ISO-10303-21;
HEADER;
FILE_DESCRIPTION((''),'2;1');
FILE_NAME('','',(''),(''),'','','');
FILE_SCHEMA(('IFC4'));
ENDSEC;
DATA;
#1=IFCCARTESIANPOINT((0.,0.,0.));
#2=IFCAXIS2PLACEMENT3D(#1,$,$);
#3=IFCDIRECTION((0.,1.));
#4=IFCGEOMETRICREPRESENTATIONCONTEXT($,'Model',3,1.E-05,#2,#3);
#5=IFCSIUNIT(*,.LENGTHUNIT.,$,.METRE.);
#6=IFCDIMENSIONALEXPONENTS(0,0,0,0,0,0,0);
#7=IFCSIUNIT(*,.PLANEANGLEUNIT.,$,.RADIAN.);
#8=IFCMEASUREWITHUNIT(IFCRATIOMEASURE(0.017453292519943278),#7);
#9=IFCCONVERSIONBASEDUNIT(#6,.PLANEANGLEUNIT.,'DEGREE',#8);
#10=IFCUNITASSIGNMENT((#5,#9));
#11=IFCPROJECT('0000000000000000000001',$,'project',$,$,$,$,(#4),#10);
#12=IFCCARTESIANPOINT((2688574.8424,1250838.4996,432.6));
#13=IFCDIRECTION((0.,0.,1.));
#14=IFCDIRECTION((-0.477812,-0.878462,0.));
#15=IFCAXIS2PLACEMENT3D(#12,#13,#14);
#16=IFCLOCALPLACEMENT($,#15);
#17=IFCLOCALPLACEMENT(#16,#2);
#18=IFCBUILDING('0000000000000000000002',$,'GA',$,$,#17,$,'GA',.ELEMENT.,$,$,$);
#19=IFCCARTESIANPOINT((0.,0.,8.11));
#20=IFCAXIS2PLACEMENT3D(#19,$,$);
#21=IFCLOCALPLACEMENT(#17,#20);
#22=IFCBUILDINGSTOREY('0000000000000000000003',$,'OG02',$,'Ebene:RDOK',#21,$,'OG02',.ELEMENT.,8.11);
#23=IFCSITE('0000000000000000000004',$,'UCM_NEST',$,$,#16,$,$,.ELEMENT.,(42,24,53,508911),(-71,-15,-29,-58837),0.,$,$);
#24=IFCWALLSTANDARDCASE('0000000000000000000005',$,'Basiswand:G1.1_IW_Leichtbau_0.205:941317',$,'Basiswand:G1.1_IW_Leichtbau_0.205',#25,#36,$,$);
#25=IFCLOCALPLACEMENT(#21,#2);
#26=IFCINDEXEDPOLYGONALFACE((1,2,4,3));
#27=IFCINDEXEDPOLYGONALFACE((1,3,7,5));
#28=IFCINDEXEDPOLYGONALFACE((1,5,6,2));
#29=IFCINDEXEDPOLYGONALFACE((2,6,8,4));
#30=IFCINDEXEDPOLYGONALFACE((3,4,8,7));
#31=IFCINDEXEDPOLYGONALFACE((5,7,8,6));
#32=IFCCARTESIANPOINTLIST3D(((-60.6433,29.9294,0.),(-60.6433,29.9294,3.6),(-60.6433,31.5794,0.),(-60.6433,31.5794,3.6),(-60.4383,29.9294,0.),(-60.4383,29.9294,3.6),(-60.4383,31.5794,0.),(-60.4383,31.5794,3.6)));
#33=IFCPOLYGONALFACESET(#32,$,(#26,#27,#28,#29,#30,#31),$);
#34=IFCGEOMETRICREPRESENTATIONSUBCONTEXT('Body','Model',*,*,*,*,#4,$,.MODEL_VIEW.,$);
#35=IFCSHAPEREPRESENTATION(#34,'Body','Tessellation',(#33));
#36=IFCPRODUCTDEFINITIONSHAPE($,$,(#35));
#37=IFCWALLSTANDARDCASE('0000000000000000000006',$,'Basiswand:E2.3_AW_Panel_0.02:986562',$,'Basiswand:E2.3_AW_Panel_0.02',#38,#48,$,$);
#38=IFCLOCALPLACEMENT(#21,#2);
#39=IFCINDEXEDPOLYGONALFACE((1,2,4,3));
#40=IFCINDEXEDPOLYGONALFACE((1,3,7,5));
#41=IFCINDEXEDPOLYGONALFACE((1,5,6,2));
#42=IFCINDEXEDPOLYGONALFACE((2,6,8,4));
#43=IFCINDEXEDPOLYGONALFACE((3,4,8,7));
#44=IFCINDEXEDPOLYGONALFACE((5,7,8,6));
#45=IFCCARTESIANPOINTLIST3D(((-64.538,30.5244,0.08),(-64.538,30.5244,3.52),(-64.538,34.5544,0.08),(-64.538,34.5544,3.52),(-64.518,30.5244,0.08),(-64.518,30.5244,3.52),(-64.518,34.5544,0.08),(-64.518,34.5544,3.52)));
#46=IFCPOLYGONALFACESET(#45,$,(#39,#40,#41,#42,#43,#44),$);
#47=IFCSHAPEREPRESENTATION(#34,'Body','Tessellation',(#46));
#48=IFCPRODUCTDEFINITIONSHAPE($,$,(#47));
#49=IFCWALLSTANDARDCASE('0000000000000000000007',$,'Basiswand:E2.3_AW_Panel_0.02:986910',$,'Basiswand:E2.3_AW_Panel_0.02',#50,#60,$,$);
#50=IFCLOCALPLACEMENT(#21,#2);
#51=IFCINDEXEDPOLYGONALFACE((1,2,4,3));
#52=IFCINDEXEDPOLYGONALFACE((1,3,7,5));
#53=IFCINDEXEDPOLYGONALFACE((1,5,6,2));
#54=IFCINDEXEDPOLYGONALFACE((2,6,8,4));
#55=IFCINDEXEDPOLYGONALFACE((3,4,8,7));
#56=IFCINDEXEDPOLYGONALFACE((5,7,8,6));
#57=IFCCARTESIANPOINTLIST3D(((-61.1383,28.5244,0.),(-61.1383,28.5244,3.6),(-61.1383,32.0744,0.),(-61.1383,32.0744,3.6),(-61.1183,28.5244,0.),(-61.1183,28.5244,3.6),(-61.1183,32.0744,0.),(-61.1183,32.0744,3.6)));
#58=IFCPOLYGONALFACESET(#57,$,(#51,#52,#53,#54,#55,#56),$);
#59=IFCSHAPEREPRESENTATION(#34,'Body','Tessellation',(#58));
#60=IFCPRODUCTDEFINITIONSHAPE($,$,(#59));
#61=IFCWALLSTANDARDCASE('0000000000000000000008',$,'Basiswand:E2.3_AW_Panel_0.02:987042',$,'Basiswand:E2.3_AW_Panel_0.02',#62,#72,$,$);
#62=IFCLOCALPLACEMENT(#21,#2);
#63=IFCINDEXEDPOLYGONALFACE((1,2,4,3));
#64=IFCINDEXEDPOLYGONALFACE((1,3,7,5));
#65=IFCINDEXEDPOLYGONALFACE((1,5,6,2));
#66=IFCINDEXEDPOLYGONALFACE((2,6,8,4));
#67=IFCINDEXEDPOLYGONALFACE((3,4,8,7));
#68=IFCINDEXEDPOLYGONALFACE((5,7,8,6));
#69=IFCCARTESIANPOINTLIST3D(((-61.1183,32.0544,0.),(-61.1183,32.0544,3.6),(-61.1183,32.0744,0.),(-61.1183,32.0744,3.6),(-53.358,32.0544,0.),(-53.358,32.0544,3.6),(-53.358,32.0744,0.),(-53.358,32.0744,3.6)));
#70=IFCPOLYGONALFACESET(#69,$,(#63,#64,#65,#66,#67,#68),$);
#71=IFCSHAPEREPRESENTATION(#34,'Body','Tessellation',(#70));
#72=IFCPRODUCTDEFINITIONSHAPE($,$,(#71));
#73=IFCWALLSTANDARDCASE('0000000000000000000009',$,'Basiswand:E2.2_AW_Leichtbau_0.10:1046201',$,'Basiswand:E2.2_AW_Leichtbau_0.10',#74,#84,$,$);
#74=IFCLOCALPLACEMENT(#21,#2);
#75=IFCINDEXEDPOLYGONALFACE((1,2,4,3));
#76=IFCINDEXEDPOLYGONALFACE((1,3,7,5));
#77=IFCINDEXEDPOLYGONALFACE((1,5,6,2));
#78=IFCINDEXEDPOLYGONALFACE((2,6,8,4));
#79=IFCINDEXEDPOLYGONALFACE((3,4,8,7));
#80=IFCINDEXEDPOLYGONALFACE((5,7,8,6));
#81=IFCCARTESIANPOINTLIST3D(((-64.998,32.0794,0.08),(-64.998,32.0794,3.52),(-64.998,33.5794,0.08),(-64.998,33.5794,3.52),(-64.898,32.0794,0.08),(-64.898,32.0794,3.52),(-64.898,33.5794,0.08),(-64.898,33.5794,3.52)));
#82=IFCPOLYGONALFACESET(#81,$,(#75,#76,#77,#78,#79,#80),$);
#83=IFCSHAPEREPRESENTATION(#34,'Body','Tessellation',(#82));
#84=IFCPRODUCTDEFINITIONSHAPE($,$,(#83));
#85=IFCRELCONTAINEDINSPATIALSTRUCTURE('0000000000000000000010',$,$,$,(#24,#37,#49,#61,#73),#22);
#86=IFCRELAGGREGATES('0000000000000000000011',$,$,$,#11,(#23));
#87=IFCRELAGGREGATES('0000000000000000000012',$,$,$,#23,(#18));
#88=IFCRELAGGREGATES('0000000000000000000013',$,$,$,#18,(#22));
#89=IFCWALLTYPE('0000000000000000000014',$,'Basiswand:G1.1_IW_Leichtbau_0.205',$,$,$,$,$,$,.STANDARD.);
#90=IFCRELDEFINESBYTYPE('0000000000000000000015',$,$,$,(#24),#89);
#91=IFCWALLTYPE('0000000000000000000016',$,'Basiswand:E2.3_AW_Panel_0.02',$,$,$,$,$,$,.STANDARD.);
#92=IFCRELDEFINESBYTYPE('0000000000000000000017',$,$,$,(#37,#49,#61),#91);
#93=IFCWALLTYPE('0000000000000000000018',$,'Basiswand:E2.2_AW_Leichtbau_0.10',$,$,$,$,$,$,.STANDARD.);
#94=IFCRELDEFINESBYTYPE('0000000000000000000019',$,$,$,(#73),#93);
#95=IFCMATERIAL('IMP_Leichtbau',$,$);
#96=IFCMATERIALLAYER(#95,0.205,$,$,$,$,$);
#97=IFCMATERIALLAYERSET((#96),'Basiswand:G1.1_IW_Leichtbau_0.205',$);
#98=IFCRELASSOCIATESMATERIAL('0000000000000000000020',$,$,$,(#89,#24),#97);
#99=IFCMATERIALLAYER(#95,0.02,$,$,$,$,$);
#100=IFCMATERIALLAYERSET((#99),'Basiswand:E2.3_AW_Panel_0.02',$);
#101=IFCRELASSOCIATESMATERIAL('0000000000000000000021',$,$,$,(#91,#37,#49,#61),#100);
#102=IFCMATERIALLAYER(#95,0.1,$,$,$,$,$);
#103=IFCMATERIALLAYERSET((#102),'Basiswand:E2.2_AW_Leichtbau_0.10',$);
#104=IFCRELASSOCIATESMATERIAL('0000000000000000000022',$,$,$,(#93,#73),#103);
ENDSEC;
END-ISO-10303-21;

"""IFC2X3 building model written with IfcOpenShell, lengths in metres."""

from ifc_helpers import new_model, entity, si_unit, converted_unit, direction, frame, frame_2d, origin, place, context, subcontext, project, spatial, polyline, rectangle, extrude, clip, bounded_halfspace, material, layer, layer_set, layer_usage, type_object, element, save


model = new_model("IFC2X3")

# Units and contexts
model_context = context("Model", 3, precision=1e-05, world=origin(), true_north=direction((0.0, 1.0)))
body_context = subcontext(model_context, "Body", "Model", "MODEL_VIEW")
ifc_project = project(units=[si_unit("LENGTHUNIT", "METRE"), converted_unit("PLANEANGLEUNIT", "DEGREE", entity("IfcRatioMeasure", 0.017453292519943278), si_unit("PLANEANGLEUNIT", "RADIAN"), dimensions=[0, 0, 0, 0, 0, 0, 0])], contexts=[model_context])

# Site, building, storey
site_placement = place(None, frame((2688574.8424, 1250838.4996, 432.6), z_axis=(0.0, 0.0, 1.0), x_axis=(-0.477812, -0.878462, 0.0)))
site = spatial("IfcSite", under=ifc_project, at=site_placement, Name="UCM_NEST", CompositionType="ELEMENT", RefLatitude=(42, 24, 53, 508911), RefLongitude=(-71, -15, -29, -58837), RefElevation=0.0)
building_placement = place(site_placement, origin())
building = spatial("IfcBuilding", under=site, at=building_placement, Name="GA", LongName="GA", CompositionType="ELEMENT")
storey_placement = place(building_placement, frame((0.0, 0.0, 8.11)))
storey = spatial("IfcBuildingStorey", under=building, at=storey_placement, Name="OG02", ObjectType="Ebene:RDOK", LongName="OG02", CompositionType="ELEMENT", Elevation=8.11)

# Walls
ifc_material_1 = material(Name="IMP_Leichtbau")
ifc_layer_1 = layer(ifc_material_1, 0.205)
ifc_layer_set_1 = layer_set([ifc_layer_1], Name="Basiswand:G1.1_IW_Leichtbau_0.205")
ifc_layer_usage_1 = layer_usage(ifc_layer_set_1, "AXIS2", "NEGATIVE", 0.1025)
wall_type_1 = type_object("IfcWallType", Name="Basiswand:G1.1_IW_Leichtbau_0.205", PredefinedType="STANDARD", material=ifc_layer_set_1)
wall_1_placement = place(storey_placement, frame((-60.5408, 31.5794, 0.0), z_axis=(0.0, 0.0, 1.0), x_axis=(0.0, -1.0, 0.0)))
element("IfcWallStandardCase", 1, at=wall_1_placement, inside=storey, type_object=wall_type_1, material=ifc_layer_usage_1, Name="Basiswand:G1.1_IW_Leichtbau_0.205:941317", ObjectType="Basiswand:G1.1_IW_Leichtbau_0.205", context=body_context, shape_type="SweptSolid", body=[
    extrude(rectangle(XDim=1.65, YDim=0.205, at=frame_2d((0.825, 0.0), x_axis=(-1.0, 0.0))), origin(), (0.0, 0.0, 1.0), 3.6),
])
ifc_layer_2 = layer(ifc_material_1, 0.02)
ifc_layer_set_2 = layer_set([ifc_layer_2], Name="Basiswand:E2.3_AW_Panel_0.02")
ifc_layer_usage_2 = layer_usage(ifc_layer_set_2, "AXIS2", "NEGATIVE", 0.01)
wall_type_2 = type_object("IfcWallType", Name="Basiswand:E2.3_AW_Panel_0.02", PredefinedType="STANDARD", material=ifc_layer_set_2)
wall_2_placement = place(storey_placement, frame((-64.528, 34.5544, 0.08), z_axis=(0.0, 0.0, 1.0), x_axis=(0.0, -1.0, 0.0)))
element("IfcWallStandardCase", 2, at=wall_2_placement, inside=storey, type_object=wall_type_2, material=ifc_layer_usage_2, Name="Basiswand:E2.3_AW_Panel_0.02:986562", ObjectType="Basiswand:E2.3_AW_Panel_0.02", context=body_context, shape_type="Clipping", body=[
    clip(clip(extrude(rectangle(XDim=4.03, YDim=0.02, at=frame_2d((2.015, 0.0), x_axis=(-1.0, 0.0))), origin(), (0.0, 0.0, 1.0), 3.44), bounded_halfspace(frame((4.03, -0.01, 0.0), z_axis=(0.0, 0.0, 1.0), x_axis=(0.0, -1.0, 0.0)), True, frame((4.03, -0.01, 0.0), z_axis=(0.0, 0.0, 1.0), x_axis=(0.0, -1.0, 0.0)), polyline([(0.0, 0.0), (-0.02, 0.0), (-0.02, -4.03), (0.0, -4.03), (0.0, 0.0)]))), bounded_halfspace(frame((0.0, -0.01, 3.44), z_axis=(0.0, 0.0, -1.0), x_axis=(0.0, -1.0, 0.0)), True, frame((0.0, -0.01, 3.44), z_axis=(0.0, 0.0, -1.0), x_axis=(0.0, -1.0, 0.0)), polyline([(0.0, 0.0), (-0.02, 0.0), (-0.02, -4.03), (0.0, -4.03), (0.0, 0.0)]))),
])
wall_3_placement = place(storey_placement, frame((-61.1283, 28.5244, 0.0), z_axis=(0.0, 0.0, 1.0), x_axis=(0.0, 1.0, 0.0)))
element("IfcWallStandardCase", 3, at=wall_3_placement, inside=storey, type_object=wall_type_2, material=ifc_layer_usage_2, Name="Basiswand:E2.3_AW_Panel_0.02:986910", ObjectType="Basiswand:E2.3_AW_Panel_0.02", context=body_context, shape_type="SweptSolid", body=[
    extrude(rectangle(XDim=3.55, YDim=0.02, at=frame_2d((1.775, 0.0), x_axis=(-1.0, 0.0))), origin(), (0.0, 0.0, 1.0), 3.6),
])
wall_4_placement = place(storey_placement, frame((-61.1183, 32.0644, 0.0)))
element("IfcWallStandardCase", 4, at=wall_4_placement, inside=storey, type_object=wall_type_2, material=ifc_layer_usage_2, Name="Basiswand:E2.3_AW_Panel_0.02:987042", ObjectType="Basiswand:E2.3_AW_Panel_0.02", context=body_context, shape_type="SweptSolid", body=[
    extrude(rectangle(XDim=7.7603, YDim=0.02, at=frame_2d((3.8801, 0.0), x_axis=(-1.0, 0.0))), origin(), (0.0, 0.0, 1.0), 3.6),
])

# Wall
ifc_layer_3 = layer(ifc_material_1, 0.1)
ifc_layer_set_3 = layer_set([ifc_layer_3], Name="Basiswand:E2.2_AW_Leichtbau_0.10")
ifc_layer_usage_3 = layer_usage(ifc_layer_set_3, "AXIS2", "NEGATIVE", 0.05)
wall_type_3 = type_object("IfcWallType", Name="Basiswand:E2.2_AW_Leichtbau_0.10", PredefinedType="STANDARD", material=ifc_layer_set_3)
wall_5_placement = place(storey_placement, frame((-64.948, 33.5794, 0.08), z_axis=(0.0, 0.0, 1.0), x_axis=(0.0, -1.0, 0.0)))
element("IfcWallStandardCase", 5, at=wall_5_placement, inside=storey, type_object=wall_type_3, material=ifc_layer_usage_3, Name="Basiswand:E2.2_AW_Leichtbau_0.10:1046201", ObjectType="Basiswand:E2.2_AW_Leichtbau_0.10", context=body_context, shape_type="Clipping", body=[
    clip(clip(extrude(rectangle(XDim=1.5, YDim=0.1, at=frame_2d((0.75, 0.0), x_axis=(-1.0, 0.0))), origin(), (0.0, 0.0, 1.0), 3.44), bounded_halfspace(frame((1.5, -0.05, 0.0), z_axis=(0.0, 0.0, 1.0), x_axis=(0.0, -1.0, 0.0)), True, frame((1.5, -0.05, 0.0), z_axis=(0.0, 0.0, 1.0), x_axis=(0.0, -1.0, 0.0)), polyline([(0.0, 0.0), (-0.1, 0.0), (-0.1, -1.5), (0.0, -1.5), (0.0, 0.0)]))), bounded_halfspace(frame((0.0, -0.05, 3.44), z_axis=(0.0, 0.0, -1.0), x_axis=(0.0, -1.0, 0.0)), True, frame((0.0, -0.05, 3.44), z_axis=(0.0, 0.0, -1.0), x_axis=(0.0, -1.0, 0.0)), polyline([(0.0, 0.0), (-0.1, 0.0), (-0.1, -1.5), (0.0, -1.5), (0.0, 0.0)]))),
])

save(model, "model.ifc")
